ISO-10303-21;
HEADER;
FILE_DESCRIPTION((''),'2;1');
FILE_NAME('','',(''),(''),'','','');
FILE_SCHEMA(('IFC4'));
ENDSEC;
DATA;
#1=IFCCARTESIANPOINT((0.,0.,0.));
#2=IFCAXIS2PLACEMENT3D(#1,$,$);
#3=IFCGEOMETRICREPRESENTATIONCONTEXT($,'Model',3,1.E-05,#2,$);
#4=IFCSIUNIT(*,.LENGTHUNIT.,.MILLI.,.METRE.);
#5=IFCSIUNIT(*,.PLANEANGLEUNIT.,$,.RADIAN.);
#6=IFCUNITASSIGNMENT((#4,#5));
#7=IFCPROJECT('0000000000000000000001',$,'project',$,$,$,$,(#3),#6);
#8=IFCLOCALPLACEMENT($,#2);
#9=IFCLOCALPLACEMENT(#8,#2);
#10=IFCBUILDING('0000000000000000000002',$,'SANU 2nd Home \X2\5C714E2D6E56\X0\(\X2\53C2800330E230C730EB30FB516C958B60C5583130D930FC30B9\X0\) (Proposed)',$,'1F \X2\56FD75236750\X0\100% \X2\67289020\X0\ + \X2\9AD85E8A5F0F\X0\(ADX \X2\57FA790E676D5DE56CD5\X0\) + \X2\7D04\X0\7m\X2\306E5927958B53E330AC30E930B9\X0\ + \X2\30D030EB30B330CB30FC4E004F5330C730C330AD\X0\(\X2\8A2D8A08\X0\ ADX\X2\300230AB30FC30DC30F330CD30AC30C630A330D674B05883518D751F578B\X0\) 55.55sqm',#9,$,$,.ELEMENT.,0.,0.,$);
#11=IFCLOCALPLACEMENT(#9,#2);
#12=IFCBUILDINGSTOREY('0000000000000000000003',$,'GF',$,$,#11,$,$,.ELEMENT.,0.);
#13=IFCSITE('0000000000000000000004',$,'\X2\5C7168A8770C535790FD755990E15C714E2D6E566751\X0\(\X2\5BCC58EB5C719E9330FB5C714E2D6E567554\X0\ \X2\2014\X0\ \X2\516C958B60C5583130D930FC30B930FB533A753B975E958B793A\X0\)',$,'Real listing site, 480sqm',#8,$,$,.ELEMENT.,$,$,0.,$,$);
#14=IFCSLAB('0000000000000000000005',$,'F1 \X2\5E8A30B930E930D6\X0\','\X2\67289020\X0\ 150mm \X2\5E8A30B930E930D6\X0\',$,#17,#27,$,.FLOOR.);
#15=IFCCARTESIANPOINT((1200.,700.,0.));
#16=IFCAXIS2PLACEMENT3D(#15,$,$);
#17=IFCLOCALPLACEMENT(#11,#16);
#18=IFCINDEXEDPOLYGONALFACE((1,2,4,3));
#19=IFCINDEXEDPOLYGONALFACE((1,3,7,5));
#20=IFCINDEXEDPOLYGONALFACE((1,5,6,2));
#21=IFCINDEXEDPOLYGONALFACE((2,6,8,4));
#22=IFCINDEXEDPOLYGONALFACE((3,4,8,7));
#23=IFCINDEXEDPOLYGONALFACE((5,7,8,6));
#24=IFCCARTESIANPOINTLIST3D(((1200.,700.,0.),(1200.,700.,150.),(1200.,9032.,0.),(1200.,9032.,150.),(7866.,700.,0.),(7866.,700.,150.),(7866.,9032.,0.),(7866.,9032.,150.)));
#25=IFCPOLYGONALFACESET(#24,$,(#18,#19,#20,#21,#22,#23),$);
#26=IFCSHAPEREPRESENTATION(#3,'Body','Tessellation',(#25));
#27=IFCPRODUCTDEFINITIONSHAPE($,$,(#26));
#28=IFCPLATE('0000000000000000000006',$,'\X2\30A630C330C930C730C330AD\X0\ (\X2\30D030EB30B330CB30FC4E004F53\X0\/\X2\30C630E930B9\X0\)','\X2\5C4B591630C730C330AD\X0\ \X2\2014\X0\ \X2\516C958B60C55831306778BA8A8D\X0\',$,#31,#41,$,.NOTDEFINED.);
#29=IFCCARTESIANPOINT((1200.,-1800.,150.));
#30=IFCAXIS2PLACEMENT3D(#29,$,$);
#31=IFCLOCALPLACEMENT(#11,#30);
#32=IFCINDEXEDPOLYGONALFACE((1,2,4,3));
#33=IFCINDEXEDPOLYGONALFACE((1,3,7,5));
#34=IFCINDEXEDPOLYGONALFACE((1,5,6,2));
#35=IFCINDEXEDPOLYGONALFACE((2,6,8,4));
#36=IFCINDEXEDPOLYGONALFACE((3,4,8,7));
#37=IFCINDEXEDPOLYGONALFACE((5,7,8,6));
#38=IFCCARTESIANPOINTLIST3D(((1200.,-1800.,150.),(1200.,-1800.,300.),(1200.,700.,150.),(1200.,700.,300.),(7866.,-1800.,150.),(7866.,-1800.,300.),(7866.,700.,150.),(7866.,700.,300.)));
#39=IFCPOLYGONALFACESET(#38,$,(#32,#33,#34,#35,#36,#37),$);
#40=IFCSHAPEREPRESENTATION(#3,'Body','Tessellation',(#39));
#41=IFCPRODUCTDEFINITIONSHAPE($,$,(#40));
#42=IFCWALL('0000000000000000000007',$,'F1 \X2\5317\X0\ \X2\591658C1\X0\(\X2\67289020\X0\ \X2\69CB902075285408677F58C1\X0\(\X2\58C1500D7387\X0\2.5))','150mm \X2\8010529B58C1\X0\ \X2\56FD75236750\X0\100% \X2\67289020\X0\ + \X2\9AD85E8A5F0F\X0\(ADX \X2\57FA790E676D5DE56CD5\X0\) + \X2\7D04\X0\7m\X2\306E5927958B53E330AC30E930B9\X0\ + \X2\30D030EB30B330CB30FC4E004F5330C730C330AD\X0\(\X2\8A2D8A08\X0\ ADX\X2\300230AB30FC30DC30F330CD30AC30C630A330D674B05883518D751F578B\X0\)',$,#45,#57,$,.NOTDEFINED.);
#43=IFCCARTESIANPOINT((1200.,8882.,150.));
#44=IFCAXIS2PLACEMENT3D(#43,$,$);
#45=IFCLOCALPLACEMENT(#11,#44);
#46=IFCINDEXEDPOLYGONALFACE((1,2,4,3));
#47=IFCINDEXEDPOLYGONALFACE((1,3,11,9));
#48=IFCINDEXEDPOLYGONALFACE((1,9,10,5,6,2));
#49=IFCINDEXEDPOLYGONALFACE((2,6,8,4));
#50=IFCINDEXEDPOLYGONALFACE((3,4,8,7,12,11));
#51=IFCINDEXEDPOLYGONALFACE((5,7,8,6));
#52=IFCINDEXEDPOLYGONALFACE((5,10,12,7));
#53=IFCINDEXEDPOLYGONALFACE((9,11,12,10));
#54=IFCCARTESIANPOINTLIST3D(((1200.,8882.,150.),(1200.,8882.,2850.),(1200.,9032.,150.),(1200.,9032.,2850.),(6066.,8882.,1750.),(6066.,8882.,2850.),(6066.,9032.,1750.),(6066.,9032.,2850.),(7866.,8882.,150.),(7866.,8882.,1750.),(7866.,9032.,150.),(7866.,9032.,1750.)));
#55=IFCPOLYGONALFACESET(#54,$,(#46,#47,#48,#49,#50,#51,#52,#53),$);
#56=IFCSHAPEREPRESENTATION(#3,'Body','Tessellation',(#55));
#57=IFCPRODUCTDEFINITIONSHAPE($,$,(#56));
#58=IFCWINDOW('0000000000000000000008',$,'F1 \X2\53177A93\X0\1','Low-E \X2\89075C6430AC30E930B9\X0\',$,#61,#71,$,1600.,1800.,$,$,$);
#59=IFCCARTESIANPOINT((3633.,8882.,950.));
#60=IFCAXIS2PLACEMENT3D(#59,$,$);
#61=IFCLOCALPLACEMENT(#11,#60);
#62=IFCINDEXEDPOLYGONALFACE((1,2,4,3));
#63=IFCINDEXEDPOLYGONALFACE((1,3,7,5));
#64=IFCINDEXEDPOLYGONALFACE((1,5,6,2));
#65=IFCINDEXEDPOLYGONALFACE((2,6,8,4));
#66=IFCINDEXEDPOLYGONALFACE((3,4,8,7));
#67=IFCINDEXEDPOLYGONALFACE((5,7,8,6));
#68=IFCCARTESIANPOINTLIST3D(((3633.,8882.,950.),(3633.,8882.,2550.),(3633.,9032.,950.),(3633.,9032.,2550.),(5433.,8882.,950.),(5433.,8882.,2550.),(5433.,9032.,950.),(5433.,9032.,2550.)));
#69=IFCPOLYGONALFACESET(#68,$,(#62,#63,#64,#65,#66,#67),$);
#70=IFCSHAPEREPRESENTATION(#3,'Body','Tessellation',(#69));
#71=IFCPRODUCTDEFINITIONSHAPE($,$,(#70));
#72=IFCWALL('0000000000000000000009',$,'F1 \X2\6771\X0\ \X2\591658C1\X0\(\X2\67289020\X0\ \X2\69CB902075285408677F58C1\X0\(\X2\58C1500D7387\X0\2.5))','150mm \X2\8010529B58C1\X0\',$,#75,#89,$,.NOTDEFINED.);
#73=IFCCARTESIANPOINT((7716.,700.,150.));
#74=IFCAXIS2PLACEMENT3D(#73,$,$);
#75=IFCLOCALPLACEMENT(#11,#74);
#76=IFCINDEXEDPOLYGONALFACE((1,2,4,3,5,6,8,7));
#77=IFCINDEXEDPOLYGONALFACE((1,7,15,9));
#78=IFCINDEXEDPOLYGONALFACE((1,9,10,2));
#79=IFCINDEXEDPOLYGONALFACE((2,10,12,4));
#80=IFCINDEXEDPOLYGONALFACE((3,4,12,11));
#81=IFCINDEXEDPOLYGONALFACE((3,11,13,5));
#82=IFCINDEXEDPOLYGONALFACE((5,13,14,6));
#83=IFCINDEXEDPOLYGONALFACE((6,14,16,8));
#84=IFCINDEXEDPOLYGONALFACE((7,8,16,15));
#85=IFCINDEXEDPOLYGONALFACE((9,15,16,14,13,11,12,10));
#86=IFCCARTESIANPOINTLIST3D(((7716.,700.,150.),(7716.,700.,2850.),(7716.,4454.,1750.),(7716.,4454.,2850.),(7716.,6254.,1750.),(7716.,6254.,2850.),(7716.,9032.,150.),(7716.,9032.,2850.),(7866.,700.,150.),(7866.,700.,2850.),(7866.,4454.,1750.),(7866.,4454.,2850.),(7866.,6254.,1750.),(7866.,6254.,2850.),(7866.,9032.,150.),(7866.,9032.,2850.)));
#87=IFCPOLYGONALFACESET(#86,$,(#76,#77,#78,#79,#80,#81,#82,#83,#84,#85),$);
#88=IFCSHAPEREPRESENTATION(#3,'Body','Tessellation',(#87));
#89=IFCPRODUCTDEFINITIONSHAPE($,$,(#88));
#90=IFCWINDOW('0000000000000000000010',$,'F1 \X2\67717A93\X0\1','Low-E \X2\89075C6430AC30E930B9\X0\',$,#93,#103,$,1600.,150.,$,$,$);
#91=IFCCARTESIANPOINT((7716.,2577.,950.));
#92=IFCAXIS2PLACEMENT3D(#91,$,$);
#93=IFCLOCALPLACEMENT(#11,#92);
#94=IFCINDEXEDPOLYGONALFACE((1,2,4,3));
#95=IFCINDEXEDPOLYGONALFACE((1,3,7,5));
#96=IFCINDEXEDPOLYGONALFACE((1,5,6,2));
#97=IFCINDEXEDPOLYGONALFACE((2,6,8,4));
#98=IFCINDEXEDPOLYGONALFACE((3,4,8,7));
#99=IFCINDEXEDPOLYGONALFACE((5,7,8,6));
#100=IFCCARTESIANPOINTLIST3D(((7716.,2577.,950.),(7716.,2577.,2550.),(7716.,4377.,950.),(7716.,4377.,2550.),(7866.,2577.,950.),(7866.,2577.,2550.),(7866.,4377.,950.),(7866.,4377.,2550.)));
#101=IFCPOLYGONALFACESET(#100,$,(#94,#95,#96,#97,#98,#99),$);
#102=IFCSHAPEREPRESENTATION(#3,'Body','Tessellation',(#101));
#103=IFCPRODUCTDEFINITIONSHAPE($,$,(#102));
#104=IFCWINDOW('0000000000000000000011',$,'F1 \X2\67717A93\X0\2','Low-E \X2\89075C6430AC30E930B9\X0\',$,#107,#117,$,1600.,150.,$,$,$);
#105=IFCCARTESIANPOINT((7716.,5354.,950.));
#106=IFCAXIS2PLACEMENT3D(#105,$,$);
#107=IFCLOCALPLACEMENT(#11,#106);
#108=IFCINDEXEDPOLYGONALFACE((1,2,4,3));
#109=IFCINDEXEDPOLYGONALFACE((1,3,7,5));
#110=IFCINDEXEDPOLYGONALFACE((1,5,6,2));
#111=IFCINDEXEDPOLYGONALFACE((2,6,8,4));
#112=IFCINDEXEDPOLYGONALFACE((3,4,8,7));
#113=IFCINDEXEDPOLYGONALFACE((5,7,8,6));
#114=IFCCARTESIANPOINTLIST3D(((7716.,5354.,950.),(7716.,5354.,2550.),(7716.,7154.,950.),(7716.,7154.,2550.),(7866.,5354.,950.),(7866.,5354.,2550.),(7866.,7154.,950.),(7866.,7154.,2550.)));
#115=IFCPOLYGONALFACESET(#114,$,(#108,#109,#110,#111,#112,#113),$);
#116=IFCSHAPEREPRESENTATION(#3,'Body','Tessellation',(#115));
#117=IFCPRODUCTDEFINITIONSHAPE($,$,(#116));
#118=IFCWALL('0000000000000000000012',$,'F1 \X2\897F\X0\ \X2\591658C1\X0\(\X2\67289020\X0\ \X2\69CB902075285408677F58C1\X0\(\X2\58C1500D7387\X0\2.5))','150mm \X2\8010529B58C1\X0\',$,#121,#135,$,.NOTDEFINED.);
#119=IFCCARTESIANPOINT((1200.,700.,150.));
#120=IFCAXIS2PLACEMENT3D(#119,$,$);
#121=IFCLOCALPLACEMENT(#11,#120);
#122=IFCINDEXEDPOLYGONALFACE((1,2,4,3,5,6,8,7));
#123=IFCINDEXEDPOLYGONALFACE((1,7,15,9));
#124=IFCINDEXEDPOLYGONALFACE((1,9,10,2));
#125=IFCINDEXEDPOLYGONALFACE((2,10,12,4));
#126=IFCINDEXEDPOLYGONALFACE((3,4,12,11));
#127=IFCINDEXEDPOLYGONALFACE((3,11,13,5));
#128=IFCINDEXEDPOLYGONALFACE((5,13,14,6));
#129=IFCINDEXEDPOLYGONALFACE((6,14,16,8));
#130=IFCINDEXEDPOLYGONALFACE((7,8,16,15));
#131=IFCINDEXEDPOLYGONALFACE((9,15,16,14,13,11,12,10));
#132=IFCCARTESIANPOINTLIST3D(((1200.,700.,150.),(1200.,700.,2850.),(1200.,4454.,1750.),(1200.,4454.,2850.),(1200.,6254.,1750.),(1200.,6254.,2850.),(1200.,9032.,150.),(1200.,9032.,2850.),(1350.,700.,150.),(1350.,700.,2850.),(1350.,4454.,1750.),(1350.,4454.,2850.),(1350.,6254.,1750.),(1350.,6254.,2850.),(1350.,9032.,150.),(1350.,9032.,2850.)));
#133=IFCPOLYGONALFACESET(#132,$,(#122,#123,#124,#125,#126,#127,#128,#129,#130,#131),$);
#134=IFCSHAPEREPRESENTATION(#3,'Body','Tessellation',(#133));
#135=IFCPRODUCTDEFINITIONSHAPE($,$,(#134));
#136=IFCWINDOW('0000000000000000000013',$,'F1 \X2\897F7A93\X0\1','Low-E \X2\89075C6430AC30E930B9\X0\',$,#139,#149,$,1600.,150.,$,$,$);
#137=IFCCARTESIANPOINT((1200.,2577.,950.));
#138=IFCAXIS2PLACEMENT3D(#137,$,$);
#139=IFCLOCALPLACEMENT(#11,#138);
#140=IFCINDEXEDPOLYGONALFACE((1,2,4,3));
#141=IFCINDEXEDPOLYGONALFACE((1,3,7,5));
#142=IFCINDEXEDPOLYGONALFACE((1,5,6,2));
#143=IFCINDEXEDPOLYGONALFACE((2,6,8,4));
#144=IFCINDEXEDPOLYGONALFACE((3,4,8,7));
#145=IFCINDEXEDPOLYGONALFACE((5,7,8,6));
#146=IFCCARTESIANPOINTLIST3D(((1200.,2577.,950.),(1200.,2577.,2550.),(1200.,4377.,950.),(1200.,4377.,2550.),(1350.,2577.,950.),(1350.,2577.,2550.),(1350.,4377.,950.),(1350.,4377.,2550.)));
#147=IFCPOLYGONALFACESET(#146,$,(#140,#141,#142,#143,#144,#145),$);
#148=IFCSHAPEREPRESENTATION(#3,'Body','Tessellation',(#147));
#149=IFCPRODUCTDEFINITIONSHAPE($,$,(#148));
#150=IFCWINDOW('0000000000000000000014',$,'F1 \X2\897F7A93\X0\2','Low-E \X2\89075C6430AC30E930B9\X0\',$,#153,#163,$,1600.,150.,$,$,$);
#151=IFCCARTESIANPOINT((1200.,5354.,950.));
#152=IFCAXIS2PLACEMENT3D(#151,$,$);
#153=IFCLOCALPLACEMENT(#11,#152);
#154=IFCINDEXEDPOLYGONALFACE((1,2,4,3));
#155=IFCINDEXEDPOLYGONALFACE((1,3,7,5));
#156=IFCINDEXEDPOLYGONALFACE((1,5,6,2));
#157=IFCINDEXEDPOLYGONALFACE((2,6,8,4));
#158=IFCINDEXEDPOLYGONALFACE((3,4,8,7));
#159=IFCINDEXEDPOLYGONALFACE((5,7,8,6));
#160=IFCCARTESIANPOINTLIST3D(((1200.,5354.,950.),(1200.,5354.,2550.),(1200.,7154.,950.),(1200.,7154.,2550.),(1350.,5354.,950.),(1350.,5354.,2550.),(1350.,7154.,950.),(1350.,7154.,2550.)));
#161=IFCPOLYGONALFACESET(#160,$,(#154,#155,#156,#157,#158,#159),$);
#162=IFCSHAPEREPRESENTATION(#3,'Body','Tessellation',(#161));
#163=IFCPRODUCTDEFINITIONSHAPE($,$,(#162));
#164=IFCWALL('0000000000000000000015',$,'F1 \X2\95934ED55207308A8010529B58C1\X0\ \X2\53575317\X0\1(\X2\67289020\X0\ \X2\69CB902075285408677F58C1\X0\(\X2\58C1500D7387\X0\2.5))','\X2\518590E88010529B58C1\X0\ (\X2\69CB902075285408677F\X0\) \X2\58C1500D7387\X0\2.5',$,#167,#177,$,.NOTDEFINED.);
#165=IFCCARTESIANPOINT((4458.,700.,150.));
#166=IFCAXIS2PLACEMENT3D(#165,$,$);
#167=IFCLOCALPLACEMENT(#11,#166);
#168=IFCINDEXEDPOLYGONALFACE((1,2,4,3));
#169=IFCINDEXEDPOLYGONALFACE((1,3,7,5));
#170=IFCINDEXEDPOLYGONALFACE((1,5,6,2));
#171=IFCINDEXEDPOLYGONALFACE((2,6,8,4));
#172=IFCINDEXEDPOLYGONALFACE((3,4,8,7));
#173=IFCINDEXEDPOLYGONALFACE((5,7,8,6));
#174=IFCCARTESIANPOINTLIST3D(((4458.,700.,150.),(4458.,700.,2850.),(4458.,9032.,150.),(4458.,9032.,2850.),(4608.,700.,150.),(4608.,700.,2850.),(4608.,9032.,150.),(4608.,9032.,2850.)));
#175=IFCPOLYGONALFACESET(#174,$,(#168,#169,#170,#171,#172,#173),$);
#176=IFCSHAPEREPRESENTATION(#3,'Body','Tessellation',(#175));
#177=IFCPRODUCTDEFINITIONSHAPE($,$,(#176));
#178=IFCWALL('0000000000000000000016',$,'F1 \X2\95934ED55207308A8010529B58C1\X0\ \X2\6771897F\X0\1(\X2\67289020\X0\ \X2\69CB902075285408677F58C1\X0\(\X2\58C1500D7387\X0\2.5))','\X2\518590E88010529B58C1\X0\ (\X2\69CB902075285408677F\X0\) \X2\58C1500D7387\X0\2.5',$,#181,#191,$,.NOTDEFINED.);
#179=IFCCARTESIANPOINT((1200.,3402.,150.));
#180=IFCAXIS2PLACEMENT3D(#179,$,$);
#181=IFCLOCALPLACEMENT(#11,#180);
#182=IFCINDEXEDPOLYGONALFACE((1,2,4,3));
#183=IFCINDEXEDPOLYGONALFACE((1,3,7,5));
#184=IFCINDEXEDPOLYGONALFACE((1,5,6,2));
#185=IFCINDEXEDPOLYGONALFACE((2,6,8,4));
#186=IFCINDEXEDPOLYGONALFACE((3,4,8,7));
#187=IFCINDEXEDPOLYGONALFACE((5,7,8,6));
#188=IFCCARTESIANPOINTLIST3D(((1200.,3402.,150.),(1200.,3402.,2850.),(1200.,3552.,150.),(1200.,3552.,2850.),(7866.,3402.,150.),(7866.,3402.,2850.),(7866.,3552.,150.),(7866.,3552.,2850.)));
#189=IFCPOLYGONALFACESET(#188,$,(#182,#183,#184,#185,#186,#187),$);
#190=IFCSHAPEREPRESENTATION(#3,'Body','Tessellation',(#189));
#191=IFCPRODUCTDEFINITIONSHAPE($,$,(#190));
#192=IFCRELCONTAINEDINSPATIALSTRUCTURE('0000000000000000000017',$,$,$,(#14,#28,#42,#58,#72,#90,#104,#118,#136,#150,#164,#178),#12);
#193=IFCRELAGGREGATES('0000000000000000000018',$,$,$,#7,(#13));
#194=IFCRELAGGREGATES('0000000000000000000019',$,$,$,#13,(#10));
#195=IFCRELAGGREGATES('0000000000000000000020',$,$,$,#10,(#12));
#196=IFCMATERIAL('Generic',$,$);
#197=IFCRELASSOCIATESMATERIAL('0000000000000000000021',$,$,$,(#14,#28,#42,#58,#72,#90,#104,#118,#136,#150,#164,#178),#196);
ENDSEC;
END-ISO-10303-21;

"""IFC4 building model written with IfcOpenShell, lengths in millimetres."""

from ifc_helpers import new_model, si_unit, frame, frame_2d, origin, place, context, project, spatial, rectangle, extrude, material, element, fill, save


model = new_model("IFC4")

# Units and contexts
model_context = context("Model", 3, precision=1e-05, world=origin())
ifc_project = project(units=[si_unit("LENGTHUNIT", "METRE", prefix="MILLI"), si_unit("PLANEANGLEUNIT", "RADIAN")], contexts=[model_context])

# Site, building, storey
site_placement = place(None, origin())
site = spatial("IfcSite", under=ifc_project, at=site_placement, Name="山梨県南都留郡山中湖村(富士山麓・山中湖畔 — 公開情報ベース・区画非開示)", ObjectType="Real listing site, 480sqm", CompositionType="ELEMENT", RefElevation=0.0)
building_placement = place(site_placement, origin())
building = spatial("IfcBuilding", under=site, at=building_placement, Name="SANU 2nd Home 山中湖(参考モデル・公開情報ベース) (Proposed)", ObjectType="1F 国産材100% 木造 + 高床式(ADX 基礎杭工法) + 約7mの大開口ガラス + バルコニー一体デッキ(設計 ADX。カーボンネガティブ環境再生型) 55.55sqm", CompositionType="ELEMENT", ElevationOfRefHeight=0.0, ElevationOfTerrain=0.0)
storey_placement = place(building_placement, origin())
storey = spatial("IfcBuildingStorey", under=building, at=storey_placement, Name="GF", CompositionType="ELEMENT", Elevation=0.0)

# Slab
ifc_material_1 = material(Name="Generic")
slab_placement = place(storey_placement, frame((1200.0, 700.0, 0.0)))
element("IfcSlab", 1, at=slab_placement, inside=storey, material=ifc_material_1, Name="F1 床スラブ", Description="木造 150mm 床スラブ", PredefinedType="FLOOR", context=model_context, shape_type="SweptSolid", body=[
    extrude(rectangle(XDim=6666.0, YDim=8332.0, at=frame_2d((3333.0, 4166.0))), frame((1200.0, 700.0, 0.0)), (0.0, 0.0, 1.0), 150.0),
])

# Plate
plate_placement = place(storey_placement, frame((1200.0, -1800.0, 150.0)))
element("IfcPlate", 2, at=plate_placement, inside=storey, material=ifc_material_1, Name="ウッドデッキ (バルコニー一体/テラス)", Description="屋外デッキ — 公開情報で確認", PredefinedType="NOTDEFINED", context=model_context, shape_type="SweptSolid", body=[
    extrude(rectangle(XDim=6666.0, YDim=2500.0, at=frame_2d((3333.0, 1250.0))), frame((1200.0, -1800.0, 150.0)), (0.0, 0.0, 1.0), 150.0),
])

# Wall, opening, window
wall_1_placement = place(storey_placement, frame((1200.0, 8882.0, 150.0)))
wall_1 = element("IfcWall", 3, at=wall_1_placement, inside=storey, material=ifc_material_1, Name="F1 北 外壁(木造 構造用合板壁(壁倍率2.5))", Description="150mm 耐力壁 国産材100% 木造 + 高床式(ADX 基礎杭工法) + 約7mの大開口ガラス + バルコニー一体デッキ(設計 ADX。カーボンネガティブ環境再生型)", PredefinedType="NOTDEFINED", context=model_context, shape_type="SweptSolid", body=[
    extrude(rectangle(XDim=6666.0, YDim=150.0, at=frame_2d((3333.0, 75.0))), frame((1200.0, 8882.0, 150.0)), (0.0, 0.0, 1.0), 2700.0),
])
opening_1_placement = place(storey_placement, frame((3633.0, 8882.0, 950.0)))
opening_1 = element("IfcOpeningElement", 4, at=opening_1_placement, cuts=wall_1, PredefinedType="NOTDEFINED", context=model_context, shape_type="SweptSolid", body=[
    extrude(rectangle(XDim=1800.0, YDim=150.0, at=frame_2d((900.0, 75.0))), frame((3633.0, 8882.0, 950.0)), (0.0, 0.0, 1.0), 1600.0),
])
window_1_placement = place(storey_placement, frame((3633.0, 8882.0, 950.0)))
window_1 = element("IfcWindow", 5, at=window_1_placement, inside=storey, material=ifc_material_1, Name="F1 北窓1", Description="Low-E 複層ガラス", OverallHeight=1600.0, OverallWidth=1800.0, context=model_context, shape_type="SweptSolid", body=[
    extrude(rectangle(XDim=1800.0, YDim=150.0, at=frame_2d((900.0, 75.0))), frame((3633.0, 8882.0, 950.0)), (0.0, 0.0, 1.0), 1600.0),
])
fill(opening_1, window_1)

# Walls, openings, windows
wall_2_placement = place(storey_placement, frame((7716.0, 700.0, 150.0)))
wall_2 = element("IfcWall", 6, at=wall_2_placement, inside=storey, material=ifc_material_1, Name="F1 東 外壁(木造 構造用合板壁(壁倍率2.5))", Description="150mm 耐力壁", PredefinedType="NOTDEFINED", context=model_context, shape_type="SweptSolid", body=[
    extrude(rectangle(XDim=150.0, YDim=8332.0, at=frame_2d((75.0, 4166.0))), frame((7716.0, 700.0, 150.0)), (0.0, 0.0, 1.0), 2700.0),
])
opening_2_placement = place(storey_placement, frame((7716.0, 2577.0, 950.0)))
opening_2 = element("IfcOpeningElement", 7, at=opening_2_placement, cuts=wall_2, PredefinedType="NOTDEFINED", context=model_context, shape_type="SweptSolid", body=[
    extrude(rectangle(XDim=150.0, YDim=1800.0, at=frame_2d((75.0, 900.0))), frame((7716.0, 2577.0, 950.0)), (0.0, 0.0, 1.0), 1600.0),
])
opening_3_placement = place(storey_placement, frame((7716.0, 5354.0, 950.0)))
opening_3 = element("IfcOpeningElement", 8, at=opening_3_placement, cuts=wall_2, PredefinedType="NOTDEFINED", context=model_context, shape_type="SweptSolid", body=[
    extrude(rectangle(XDim=150.0, YDim=1800.0, at=frame_2d((75.0, 900.0))), frame((7716.0, 5354.0, 950.0)), (0.0, 0.0, 1.0), 1600.0),
])
window_2_placement = place(storey_placement, frame((7716.0, 2577.0, 950.0)))
window_2 = element("IfcWindow", 9, at=window_2_placement, inside=storey, material=ifc_material_1, Name="F1 東窓1", Description="Low-E 複層ガラス", OverallHeight=1600.0, OverallWidth=150.0, context=model_context, shape_type="SweptSolid", body=[
    extrude(rectangle(XDim=150.0, YDim=1800.0, at=frame_2d((75.0, 900.0))), frame((7716.0, 2577.0, 950.0)), (0.0, 0.0, 1.0), 1600.0),
])
fill(opening_2, window_2)
window_3_placement = place(storey_placement, frame((7716.0, 5354.0, 950.0)))
window_3 = element("IfcWindow", 10, at=window_3_placement, inside=storey, material=ifc_material_1, Name="F1 東窓2", Description="Low-E 複層ガラス", OverallHeight=1600.0, OverallWidth=150.0, context=model_context, shape_type="SweptSolid", body=[
    extrude(rectangle(XDim=150.0, YDim=1800.0, at=frame_2d((75.0, 900.0))), frame((7716.0, 5354.0, 950.0)), (0.0, 0.0, 1.0), 1600.0),
])
fill(opening_3, window_3)
wall_3_placement = place(storey_placement, frame((1200.0, 700.0, 150.0)))
wall_3 = element("IfcWall", 11, at=wall_3_placement, inside=storey, material=ifc_material_1, Name="F1 西 外壁(木造 構造用合板壁(壁倍率2.5))", Description="150mm 耐力壁", PredefinedType="NOTDEFINED", context=model_context, shape_type="SweptSolid", body=[
    extrude(rectangle(XDim=150.0, YDim=8332.0, at=frame_2d((75.0, 4166.0))), frame((1200.0, 700.0, 150.0)), (0.0, 0.0, 1.0), 2700.0),
])
opening_4_placement = place(storey_placement, frame((1200.0, 2577.0, 950.0)))
opening_4 = element("IfcOpeningElement", 12, at=opening_4_placement, cuts=wall_3, PredefinedType="NOTDEFINED", context=model_context, shape_type="SweptSolid", body=[
    extrude(rectangle(XDim=150.0, YDim=1800.0, at=frame_2d((75.0, 900.0))), frame((1200.0, 2577.0, 950.0)), (0.0, 0.0, 1.0), 1600.0),
])
opening_5_placement = place(storey_placement, frame((1200.0, 5354.0, 950.0)))
opening_5 = element("IfcOpeningElement", 13, at=opening_5_placement, cuts=wall_3, PredefinedType="NOTDEFINED", context=model_context, shape_type="SweptSolid", body=[
    extrude(rectangle(XDim=150.0, YDim=1800.0, at=frame_2d((75.0, 900.0))), frame((1200.0, 5354.0, 950.0)), (0.0, 0.0, 1.0), 1600.0),
])
window_4_placement = place(storey_placement, frame((1200.0, 2577.0, 950.0)))
window_4 = element("IfcWindow", 14, at=window_4_placement, inside=storey, material=ifc_material_1, Name="F1 西窓1", Description="Low-E 複層ガラス", OverallHeight=1600.0, OverallWidth=150.0, context=model_context, shape_type="SweptSolid", body=[
    extrude(rectangle(XDim=150.0, YDim=1800.0, at=frame_2d((75.0, 900.0))), frame((1200.0, 2577.0, 950.0)), (0.0, 0.0, 1.0), 1600.0),
])
fill(opening_4, window_4)
window_5_placement = place(storey_placement, frame((1200.0, 5354.0, 950.0)))
window_5 = element("IfcWindow", 15, at=window_5_placement, inside=storey, material=ifc_material_1, Name="F1 西窓2", Description="Low-E 複層ガラス", OverallHeight=1600.0, OverallWidth=150.0, context=model_context, shape_type="SweptSolid", body=[
    extrude(rectangle(XDim=150.0, YDim=1800.0, at=frame_2d((75.0, 900.0))), frame((1200.0, 5354.0, 950.0)), (0.0, 0.0, 1.0), 1600.0),
])
fill(opening_5, window_5)

# Walls
wall_4_placement = place(storey_placement, frame((4458.0, 700.0, 150.0)))
element("IfcWall", 16, at=wall_4_placement, inside=storey, material=ifc_material_1, Name="F1 間仕切り耐力壁 南北1(木造 構造用合板壁(壁倍率2.5))", Description="内部耐力壁 (構造用合板) 壁倍率2.5", PredefinedType="NOTDEFINED", context=model_context, shape_type="SweptSolid", body=[
    extrude(rectangle(XDim=150.0, YDim=8332.0, at=frame_2d((75.0, 4166.0))), frame((4458.0, 700.0, 150.0)), (0.0, 0.0, 1.0), 2700.0),
])
wall_5_placement = place(storey_placement, frame((1200.0, 3402.0, 150.0)))
element("IfcWall", 17, at=wall_5_placement, inside=storey, material=ifc_material_1, Name="F1 間仕切り耐力壁 東西1(木造 構造用合板壁(壁倍率2.5))", Description="内部耐力壁 (構造用合板) 壁倍率2.5", PredefinedType="NOTDEFINED", context=model_context, shape_type="SweptSolid", body=[
    extrude(rectangle(XDim=6666.0, YDim=150.0, at=frame_2d((3333.0, 75.0))), frame((1200.0, 3402.0, 150.0)), (0.0, 0.0, 1.0), 2700.0),
])

save(model, "model.ifc")
